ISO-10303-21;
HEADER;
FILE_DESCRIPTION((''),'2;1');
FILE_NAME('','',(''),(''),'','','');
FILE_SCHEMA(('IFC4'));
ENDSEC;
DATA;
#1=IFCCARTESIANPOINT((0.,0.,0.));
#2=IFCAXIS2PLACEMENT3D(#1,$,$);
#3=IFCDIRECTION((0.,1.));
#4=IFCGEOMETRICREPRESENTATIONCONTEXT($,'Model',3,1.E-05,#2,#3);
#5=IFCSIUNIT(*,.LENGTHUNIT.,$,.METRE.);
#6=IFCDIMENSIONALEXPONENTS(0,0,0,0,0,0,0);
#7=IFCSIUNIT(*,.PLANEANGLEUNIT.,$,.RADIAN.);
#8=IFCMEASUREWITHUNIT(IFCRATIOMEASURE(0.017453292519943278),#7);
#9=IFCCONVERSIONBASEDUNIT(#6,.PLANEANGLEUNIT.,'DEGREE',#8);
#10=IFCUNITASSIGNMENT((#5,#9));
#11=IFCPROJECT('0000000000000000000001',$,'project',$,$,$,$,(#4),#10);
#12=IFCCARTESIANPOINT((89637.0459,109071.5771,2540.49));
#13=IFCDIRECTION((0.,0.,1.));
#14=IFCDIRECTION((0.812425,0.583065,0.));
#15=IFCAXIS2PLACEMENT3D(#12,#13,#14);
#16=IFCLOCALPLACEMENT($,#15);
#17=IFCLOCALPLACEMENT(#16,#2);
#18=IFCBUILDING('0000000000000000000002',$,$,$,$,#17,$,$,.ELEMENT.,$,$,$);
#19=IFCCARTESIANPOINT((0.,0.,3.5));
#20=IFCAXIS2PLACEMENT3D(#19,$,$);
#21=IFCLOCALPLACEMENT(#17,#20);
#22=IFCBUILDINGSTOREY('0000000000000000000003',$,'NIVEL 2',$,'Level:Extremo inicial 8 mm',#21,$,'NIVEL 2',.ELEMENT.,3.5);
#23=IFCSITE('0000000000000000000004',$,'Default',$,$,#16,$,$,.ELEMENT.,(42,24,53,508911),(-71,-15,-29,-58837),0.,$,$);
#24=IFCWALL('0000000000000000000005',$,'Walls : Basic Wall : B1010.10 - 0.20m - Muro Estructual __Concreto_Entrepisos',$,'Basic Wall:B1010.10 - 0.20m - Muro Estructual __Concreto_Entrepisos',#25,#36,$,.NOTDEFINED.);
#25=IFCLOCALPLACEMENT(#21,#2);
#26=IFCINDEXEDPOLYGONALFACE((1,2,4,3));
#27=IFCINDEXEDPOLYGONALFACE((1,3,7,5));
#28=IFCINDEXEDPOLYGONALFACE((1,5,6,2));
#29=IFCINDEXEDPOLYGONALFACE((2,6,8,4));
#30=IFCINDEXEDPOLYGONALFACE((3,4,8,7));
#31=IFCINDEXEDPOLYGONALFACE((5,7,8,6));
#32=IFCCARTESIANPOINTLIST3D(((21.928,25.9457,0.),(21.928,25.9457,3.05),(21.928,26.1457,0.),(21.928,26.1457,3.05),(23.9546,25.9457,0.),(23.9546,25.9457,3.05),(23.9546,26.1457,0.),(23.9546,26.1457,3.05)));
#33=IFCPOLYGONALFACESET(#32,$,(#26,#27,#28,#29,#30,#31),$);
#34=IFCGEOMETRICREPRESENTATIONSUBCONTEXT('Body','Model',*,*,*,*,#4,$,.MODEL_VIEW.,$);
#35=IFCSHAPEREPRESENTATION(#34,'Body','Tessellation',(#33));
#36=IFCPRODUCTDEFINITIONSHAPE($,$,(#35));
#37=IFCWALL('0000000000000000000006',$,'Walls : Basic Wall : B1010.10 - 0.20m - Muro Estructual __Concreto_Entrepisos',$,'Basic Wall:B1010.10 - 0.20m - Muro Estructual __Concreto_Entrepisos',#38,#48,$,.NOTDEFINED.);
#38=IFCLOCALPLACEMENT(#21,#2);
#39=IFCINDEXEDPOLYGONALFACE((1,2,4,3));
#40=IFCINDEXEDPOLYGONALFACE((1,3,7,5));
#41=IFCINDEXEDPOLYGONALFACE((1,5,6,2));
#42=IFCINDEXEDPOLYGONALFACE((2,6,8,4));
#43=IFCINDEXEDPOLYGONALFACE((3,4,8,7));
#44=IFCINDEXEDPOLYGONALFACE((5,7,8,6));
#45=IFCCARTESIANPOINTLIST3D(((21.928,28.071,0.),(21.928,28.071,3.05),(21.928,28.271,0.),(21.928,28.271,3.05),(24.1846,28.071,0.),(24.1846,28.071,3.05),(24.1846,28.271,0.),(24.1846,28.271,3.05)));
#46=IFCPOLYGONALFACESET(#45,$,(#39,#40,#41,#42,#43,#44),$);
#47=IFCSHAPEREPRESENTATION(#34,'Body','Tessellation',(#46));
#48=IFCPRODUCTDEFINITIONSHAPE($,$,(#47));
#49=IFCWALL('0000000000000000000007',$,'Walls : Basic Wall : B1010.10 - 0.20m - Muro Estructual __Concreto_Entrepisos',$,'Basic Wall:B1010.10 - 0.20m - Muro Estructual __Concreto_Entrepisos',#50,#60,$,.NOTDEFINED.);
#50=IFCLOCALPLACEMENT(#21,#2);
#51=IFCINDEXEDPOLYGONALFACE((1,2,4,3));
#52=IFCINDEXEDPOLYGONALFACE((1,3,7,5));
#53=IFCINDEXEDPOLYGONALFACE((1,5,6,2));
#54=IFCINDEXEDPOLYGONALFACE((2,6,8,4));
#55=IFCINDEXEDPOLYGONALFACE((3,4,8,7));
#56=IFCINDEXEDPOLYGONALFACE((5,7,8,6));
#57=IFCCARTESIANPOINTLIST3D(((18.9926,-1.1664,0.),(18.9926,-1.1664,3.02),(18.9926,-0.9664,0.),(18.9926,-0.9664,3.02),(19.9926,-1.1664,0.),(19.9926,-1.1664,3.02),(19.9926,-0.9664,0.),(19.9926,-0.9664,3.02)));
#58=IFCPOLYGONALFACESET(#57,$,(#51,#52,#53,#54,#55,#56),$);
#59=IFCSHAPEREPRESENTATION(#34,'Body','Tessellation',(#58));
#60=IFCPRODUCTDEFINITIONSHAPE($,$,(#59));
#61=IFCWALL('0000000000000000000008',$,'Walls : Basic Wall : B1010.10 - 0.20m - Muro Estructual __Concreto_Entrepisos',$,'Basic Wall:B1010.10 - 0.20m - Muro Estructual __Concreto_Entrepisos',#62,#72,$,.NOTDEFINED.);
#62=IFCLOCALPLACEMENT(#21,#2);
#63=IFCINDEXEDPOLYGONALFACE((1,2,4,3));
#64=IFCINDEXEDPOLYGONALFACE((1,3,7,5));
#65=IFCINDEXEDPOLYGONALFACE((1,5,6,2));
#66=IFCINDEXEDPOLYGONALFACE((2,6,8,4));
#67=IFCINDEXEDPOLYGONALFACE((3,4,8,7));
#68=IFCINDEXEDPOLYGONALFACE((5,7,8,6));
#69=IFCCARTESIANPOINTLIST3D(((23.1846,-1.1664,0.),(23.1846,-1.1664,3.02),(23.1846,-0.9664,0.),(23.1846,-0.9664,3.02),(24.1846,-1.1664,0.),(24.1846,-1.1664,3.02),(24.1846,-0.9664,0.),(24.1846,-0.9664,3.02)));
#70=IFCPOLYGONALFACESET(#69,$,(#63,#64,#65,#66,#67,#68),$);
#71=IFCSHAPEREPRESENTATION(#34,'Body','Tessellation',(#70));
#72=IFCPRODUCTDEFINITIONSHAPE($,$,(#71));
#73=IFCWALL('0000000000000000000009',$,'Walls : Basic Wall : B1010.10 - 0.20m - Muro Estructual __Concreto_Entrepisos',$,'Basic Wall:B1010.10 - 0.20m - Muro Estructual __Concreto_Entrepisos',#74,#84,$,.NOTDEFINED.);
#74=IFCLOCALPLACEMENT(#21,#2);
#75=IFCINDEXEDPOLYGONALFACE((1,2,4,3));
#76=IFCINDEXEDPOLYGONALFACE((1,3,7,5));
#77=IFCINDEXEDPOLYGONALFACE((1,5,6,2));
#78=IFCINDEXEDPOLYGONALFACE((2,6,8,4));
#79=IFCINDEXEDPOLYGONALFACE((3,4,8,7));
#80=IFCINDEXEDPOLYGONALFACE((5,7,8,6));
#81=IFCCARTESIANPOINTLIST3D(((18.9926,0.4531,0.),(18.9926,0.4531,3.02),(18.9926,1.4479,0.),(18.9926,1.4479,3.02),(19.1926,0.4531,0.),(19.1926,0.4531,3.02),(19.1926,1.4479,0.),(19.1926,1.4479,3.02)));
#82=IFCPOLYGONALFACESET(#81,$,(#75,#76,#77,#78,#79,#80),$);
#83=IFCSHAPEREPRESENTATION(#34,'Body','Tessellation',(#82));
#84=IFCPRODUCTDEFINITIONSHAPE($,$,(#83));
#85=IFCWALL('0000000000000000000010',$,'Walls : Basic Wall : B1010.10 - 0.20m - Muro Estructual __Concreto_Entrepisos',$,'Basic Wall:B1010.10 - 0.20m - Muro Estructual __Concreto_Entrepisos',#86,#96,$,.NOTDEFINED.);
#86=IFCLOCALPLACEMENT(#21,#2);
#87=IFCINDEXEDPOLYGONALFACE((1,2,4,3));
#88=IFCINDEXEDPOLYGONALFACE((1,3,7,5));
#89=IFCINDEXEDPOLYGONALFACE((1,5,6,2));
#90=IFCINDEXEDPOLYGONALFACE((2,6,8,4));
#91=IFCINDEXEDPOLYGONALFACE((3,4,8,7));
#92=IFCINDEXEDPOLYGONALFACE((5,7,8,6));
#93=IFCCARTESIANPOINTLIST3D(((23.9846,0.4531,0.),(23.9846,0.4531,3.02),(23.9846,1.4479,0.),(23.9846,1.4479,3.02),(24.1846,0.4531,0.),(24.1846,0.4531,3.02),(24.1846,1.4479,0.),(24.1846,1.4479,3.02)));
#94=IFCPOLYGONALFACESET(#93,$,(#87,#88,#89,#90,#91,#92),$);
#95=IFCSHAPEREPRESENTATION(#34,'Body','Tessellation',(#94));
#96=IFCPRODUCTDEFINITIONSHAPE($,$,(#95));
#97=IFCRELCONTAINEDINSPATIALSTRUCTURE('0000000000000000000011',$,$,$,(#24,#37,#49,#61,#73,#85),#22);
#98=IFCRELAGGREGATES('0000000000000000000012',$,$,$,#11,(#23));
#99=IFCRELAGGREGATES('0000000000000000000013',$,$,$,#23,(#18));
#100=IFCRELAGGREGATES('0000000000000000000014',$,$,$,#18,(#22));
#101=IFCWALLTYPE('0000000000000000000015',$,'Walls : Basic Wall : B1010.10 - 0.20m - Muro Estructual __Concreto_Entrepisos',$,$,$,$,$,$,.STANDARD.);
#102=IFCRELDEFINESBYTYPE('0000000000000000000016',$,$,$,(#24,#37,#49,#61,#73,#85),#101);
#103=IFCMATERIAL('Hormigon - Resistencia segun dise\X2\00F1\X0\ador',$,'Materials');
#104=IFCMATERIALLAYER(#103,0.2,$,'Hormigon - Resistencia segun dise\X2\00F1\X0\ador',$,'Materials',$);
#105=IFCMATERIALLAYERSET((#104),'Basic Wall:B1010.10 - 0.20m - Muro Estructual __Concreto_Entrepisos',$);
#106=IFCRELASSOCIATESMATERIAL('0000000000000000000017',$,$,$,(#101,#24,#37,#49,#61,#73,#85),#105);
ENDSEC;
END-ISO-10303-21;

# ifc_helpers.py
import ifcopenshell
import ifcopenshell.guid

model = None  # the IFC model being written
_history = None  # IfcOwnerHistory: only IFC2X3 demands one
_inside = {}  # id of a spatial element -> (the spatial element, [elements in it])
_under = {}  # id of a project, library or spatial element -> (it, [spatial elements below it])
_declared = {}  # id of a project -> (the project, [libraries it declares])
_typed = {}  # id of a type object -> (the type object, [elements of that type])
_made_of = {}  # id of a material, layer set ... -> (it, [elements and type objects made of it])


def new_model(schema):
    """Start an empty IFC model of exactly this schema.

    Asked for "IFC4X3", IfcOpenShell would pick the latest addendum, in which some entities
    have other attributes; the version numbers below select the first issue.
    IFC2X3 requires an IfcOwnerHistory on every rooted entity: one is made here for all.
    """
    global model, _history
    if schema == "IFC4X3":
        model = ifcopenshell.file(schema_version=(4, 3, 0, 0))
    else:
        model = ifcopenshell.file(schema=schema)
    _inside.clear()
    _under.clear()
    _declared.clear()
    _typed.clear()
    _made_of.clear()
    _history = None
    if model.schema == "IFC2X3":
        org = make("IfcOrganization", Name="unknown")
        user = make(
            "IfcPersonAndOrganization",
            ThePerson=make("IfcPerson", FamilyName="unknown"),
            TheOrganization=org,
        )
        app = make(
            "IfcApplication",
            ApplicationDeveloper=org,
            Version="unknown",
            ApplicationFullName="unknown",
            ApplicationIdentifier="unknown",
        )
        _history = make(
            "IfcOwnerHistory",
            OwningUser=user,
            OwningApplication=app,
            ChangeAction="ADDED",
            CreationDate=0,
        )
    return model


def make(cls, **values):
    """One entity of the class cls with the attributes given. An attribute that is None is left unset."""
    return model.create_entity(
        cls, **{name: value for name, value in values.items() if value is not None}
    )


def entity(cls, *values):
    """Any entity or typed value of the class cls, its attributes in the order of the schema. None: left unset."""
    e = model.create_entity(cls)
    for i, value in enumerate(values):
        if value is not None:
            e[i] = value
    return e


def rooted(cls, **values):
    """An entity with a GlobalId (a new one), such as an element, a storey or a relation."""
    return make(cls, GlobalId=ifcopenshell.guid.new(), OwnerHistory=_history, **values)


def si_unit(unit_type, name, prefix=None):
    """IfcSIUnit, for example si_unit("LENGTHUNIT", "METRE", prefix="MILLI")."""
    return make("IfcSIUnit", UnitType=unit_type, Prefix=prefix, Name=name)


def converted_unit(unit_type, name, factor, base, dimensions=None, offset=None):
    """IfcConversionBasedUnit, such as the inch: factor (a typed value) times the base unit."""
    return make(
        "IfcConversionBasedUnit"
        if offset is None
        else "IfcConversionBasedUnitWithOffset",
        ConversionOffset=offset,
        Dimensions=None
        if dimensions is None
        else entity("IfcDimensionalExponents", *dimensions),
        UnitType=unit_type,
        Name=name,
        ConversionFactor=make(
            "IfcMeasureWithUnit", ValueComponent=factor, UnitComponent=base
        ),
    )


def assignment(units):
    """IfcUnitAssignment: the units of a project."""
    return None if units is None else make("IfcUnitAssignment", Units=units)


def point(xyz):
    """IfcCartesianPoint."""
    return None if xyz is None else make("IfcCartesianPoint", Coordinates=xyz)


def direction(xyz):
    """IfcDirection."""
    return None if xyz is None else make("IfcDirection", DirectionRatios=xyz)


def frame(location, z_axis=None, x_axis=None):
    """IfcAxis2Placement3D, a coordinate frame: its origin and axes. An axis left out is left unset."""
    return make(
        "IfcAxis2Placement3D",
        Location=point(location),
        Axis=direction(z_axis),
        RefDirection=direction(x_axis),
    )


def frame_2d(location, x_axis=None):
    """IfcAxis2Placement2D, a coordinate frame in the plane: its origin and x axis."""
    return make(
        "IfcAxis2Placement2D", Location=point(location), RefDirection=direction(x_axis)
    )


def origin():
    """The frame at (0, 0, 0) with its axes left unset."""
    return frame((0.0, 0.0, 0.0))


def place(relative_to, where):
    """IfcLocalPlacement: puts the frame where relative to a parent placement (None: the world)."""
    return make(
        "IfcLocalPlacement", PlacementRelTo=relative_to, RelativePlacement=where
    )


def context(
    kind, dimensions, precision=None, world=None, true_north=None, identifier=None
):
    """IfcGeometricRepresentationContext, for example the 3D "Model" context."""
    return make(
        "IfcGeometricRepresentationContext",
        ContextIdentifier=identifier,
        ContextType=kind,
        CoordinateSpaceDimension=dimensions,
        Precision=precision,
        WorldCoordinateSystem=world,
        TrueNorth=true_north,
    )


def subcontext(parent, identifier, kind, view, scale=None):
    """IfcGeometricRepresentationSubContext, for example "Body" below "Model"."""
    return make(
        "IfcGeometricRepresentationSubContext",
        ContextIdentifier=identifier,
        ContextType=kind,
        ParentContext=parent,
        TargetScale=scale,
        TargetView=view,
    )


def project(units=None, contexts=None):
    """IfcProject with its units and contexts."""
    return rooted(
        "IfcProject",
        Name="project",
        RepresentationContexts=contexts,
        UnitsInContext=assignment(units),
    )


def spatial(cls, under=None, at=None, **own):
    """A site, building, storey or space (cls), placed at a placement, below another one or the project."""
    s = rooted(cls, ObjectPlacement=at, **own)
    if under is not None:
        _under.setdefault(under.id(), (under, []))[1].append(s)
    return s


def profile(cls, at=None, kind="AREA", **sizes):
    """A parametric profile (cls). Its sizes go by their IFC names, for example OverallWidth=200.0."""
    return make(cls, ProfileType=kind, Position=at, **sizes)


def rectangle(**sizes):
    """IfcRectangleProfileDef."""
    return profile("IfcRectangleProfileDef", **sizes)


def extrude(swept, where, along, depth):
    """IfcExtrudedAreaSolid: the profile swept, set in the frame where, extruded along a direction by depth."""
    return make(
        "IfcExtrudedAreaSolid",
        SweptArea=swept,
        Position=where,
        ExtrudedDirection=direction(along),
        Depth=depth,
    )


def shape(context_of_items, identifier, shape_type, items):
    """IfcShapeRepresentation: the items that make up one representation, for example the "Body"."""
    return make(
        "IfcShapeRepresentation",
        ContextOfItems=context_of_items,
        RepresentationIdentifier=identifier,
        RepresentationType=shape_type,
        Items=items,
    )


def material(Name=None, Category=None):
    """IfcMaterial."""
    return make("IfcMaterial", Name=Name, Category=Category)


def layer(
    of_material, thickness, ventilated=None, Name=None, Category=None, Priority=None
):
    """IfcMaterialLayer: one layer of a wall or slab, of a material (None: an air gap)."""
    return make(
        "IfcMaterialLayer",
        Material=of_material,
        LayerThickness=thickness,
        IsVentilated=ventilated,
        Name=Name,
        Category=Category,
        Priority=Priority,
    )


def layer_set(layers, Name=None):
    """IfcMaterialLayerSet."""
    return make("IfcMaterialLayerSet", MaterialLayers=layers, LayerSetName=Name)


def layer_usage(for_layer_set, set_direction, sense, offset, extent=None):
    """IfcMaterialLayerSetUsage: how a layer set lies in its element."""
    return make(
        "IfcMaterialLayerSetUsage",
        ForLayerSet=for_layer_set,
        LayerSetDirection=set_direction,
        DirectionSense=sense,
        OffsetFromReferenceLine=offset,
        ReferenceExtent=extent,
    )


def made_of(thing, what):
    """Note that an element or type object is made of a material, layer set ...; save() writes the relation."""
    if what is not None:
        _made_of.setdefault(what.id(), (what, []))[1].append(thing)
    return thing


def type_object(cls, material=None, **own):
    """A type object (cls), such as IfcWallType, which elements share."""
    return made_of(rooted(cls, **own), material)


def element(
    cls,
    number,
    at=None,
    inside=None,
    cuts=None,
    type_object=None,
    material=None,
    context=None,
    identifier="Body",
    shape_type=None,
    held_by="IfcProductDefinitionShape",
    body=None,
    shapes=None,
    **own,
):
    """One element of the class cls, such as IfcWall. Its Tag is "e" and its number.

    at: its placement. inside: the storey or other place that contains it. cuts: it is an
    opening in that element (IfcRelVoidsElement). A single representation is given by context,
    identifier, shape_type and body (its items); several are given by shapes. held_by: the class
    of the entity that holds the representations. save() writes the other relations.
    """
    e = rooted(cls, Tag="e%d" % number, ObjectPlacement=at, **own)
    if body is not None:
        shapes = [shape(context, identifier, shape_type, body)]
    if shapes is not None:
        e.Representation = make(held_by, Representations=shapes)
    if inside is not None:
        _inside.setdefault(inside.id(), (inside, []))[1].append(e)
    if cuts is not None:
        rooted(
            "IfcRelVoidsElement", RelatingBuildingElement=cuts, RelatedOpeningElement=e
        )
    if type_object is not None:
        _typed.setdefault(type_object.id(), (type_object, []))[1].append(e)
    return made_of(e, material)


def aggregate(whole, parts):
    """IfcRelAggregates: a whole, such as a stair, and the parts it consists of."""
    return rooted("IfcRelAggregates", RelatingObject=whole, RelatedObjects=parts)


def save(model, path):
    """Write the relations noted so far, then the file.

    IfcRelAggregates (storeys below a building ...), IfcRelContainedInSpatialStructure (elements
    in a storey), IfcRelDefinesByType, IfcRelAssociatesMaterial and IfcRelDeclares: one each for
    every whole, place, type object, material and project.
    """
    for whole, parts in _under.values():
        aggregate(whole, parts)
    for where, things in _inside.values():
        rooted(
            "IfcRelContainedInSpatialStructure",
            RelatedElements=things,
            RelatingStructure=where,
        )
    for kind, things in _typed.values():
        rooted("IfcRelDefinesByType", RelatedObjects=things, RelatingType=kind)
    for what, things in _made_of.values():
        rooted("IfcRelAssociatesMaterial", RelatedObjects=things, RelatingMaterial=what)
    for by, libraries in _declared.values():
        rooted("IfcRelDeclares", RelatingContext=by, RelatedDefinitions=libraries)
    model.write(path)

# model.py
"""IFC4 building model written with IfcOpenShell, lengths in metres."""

from ifc_helpers import new_model, entity, si_unit, converted_unit, direction, frame, frame_2d, origin, place, context, subcontext, project, spatial, rectangle, extrude, material, layer, layer_set, layer_usage, type_object, element, save


model = new_model("IFC4")

# Units and contexts
model_context = context("Model", 3, precision=1e-05, world=origin(), true_north=direction((0.0, 1.0)))
body_context = subcontext(model_context, "Body", "Model", "MODEL_VIEW")
ifc_project = project(units=[si_unit("LENGTHUNIT", "METRE"), converted_unit("PLANEANGLEUNIT", "DEGREE", entity("IfcRatioMeasure", 0.017453292519943278), si_unit("PLANEANGLEUNIT", "RADIAN"), dimensions=[0, 0, 0, 0, 0, 0, 0])], contexts=[model_context])

# Site, building, storey
site_placement = place(None, frame((89637.0459, 109071.5771, 2540.49), z_axis=(0.0, 0.0, 1.0), x_axis=(0.812425, 0.583065, 0.0)))
site = spatial("IfcSite", under=ifc_project, at=site_placement, Name="Default", CompositionType="ELEMENT", RefLatitude=(42, 24, 53, 508911), RefLongitude=(-71, -15, -29, -58837), RefElevation=0.0)
building_placement = place(site_placement, origin())
building = spatial("IfcBuilding", under=site, at=building_placement, CompositionType="ELEMENT")
storey_placement = place(building_placement, frame((0.0, 0.0, 3.5)))
storey = spatial("IfcBuildingStorey", under=building, at=storey_placement, Name="NIVEL 2", ObjectType="Level:Extremo inicial 8 mm", LongName="NIVEL 2", CompositionType="ELEMENT", Elevation=3.5)

# Shared definitions
ifc_material_1 = material(Name="Hormigon - Resistencia segun diseñador", Category="Materials")

# Walls
ifc_layer_1 = layer(ifc_material_1, 0.2, Name="Hormigon - Resistencia segun diseñador", Category="Materials")
ifc_layer_set_1 = layer_set([ifc_layer_1], Name="Basic Wall:B1010.10 - 0.20m - Muro Estructual __Concreto_Entrepisos")
wall_type = type_object("IfcWallType", Name="Walls : Basic Wall : B1010.10 - 0.20m - Muro Estructual __Concreto_Entrepisos", PredefinedType="STANDARD", material=ifc_layer_set_1)
ifc_layer_usage_1 = layer_usage(ifc_layer_set_1, "AXIS2", "NEGATIVE", 0.1)
wall_1_placement = place(storey_placement, frame((21.928, 26.0457, 0.0)))
element("IfcWall", 1, at=wall_1_placement, inside=storey, type_object=wall_type, material=ifc_layer_usage_1, Name="Walls : Basic Wall : B1010.10 - 0.20m - Muro Estructual __Concreto_Entrepisos", ObjectType="Basic Wall:B1010.10 - 0.20m - Muro Estructual __Concreto_Entrepisos", PredefinedType="NOTDEFINED", context=body_context, shape_type="SweptSolid", body=[
    extrude(rectangle(XDim=2.0266, YDim=0.2, at=frame_2d((1.0133, 0.0), x_axis=(-1.0, 0.0))), origin(), (0.0, 0.0, 1.0), 3.05),
])
ifc_layer_usage_2 = layer_usage(ifc_layer_set_1, "AXIS2", "NEGATIVE", 0.1)
wall_2_placement = place(storey_placement, frame((21.928, 28.171, 0.0)))
element("IfcWall", 2, at=wall_2_placement, inside=storey, type_object=wall_type, material=ifc_layer_usage_2, Name="Walls : Basic Wall : B1010.10 - 0.20m - Muro Estructual __Concreto_Entrepisos", ObjectType="Basic Wall:B1010.10 - 0.20m - Muro Estructual __Concreto_Entrepisos", PredefinedType="NOTDEFINED", context=body_context, shape_type="SweptSolid", body=[
    extrude(rectangle(XDim=2.2566, YDim=0.2, at=frame_2d((1.1283, 0.0), x_axis=(-1.0, 0.0))), origin(), (0.0, 0.0, 1.0), 3.05),
])
ifc_layer_usage_3 = layer_usage(ifc_layer_set_1, "AXIS2", "NEGATIVE", 0.1)
wall_3_placement = place(storey_placement, frame((18.9926, -1.0664, 0.0)))
element("IfcWall", 3, at=wall_3_placement, inside=storey, type_object=wall_type, material=ifc_layer_usage_3, Name="Walls : Basic Wall : B1010.10 - 0.20m - Muro Estructual __Concreto_Entrepisos", ObjectType="Basic Wall:B1010.10 - 0.20m - Muro Estructual __Concreto_Entrepisos", PredefinedType="NOTDEFINED", context=body_context, shape_type="SweptSolid", body=[
    extrude(rectangle(XDim=1.0, YDim=0.2, at=frame_2d((0.5, 0.0), x_axis=(-1.0, 0.0))), origin(), (0.0, 0.0, 1.0), 3.02),
])
ifc_layer_usage_4 = layer_usage(ifc_layer_set_1, "AXIS2", "NEGATIVE", 0.1)
wall_4_placement = place(storey_placement, frame((23.1846, -1.0664, 0.0)))
element("IfcWall", 4, at=wall_4_placement, inside=storey, type_object=wall_type, material=ifc_layer_usage_4, Name="Walls : Basic Wall : B1010.10 - 0.20m - Muro Estructual __Concreto_Entrepisos", ObjectType="Basic Wall:B1010.10 - 0.20m - Muro Estructual __Concreto_Entrepisos", PredefinedType="NOTDEFINED", context=body_context, shape_type="SweptSolid", body=[
    extrude(rectangle(XDim=1.0, YDim=0.2, at=frame_2d((0.5, 0.0), x_axis=(-1.0, 0.0))), origin(), (0.0, 0.0, 1.0), 3.02),
])
ifc_layer_usage_5 = layer_usage(ifc_layer_set_1, "AXIS2", "NEGATIVE", 0.1)
wall_5_placement = place(storey_placement, frame((19.0926, 0.4531, 0.0), z_axis=(0.0, 0.0, 1.0), x_axis=(0.0, 1.0, 0.0)))
element("IfcWall", 5, at=wall_5_placement, inside=storey, type_object=wall_type, material=ifc_layer_usage_5, Name="Walls : Basic Wall : B1010.10 - 0.20m - Muro Estructual __Concreto_Entrepisos", ObjectType="Basic Wall:B1010.10 - 0.20m - Muro Estructual __Concreto_Entrepisos", PredefinedType="NOTDEFINED", context=body_context, shape_type="SweptSolid", body=[
    extrude(rectangle(XDim=0.9948, YDim=0.2, at=frame_2d((0.4974, 0.0), x_axis=(-1.0, 0.0))), origin(), (0.0, 0.0, 1.0), 3.02),
])
ifc_layer_usage_6 = layer_usage(ifc_layer_set_1, "AXIS2", "NEGATIVE", 0.1)
wall_6_placement = place(storey_placement, frame((24.0846, 0.4531, 0.0), z_axis=(0.0, 0.0, 1.0), x_axis=(0.0, 1.0, 0.0)))
element("IfcWall", 6, at=wall_6_placement, inside=storey, type_object=wall_type, material=ifc_layer_usage_6, Name="Walls : Basic Wall : B1010.10 - 0.20m - Muro Estructual __Concreto_Entrepisos", ObjectType="Basic Wall:B1010.10 - 0.20m - Muro Estructual __Concreto_Entrepisos", PredefinedType="NOTDEFINED", context=body_context, shape_type="SweptSolid", body=[
    extrude(rectangle(XDim=0.9948, YDim=0.2, at=frame_2d((0.4974, 0.0), x_axis=(-1.0, 0.0))), origin(), (0.0, 0.0, 1.0), 3.02),
])

save(model, "model.ifc")
